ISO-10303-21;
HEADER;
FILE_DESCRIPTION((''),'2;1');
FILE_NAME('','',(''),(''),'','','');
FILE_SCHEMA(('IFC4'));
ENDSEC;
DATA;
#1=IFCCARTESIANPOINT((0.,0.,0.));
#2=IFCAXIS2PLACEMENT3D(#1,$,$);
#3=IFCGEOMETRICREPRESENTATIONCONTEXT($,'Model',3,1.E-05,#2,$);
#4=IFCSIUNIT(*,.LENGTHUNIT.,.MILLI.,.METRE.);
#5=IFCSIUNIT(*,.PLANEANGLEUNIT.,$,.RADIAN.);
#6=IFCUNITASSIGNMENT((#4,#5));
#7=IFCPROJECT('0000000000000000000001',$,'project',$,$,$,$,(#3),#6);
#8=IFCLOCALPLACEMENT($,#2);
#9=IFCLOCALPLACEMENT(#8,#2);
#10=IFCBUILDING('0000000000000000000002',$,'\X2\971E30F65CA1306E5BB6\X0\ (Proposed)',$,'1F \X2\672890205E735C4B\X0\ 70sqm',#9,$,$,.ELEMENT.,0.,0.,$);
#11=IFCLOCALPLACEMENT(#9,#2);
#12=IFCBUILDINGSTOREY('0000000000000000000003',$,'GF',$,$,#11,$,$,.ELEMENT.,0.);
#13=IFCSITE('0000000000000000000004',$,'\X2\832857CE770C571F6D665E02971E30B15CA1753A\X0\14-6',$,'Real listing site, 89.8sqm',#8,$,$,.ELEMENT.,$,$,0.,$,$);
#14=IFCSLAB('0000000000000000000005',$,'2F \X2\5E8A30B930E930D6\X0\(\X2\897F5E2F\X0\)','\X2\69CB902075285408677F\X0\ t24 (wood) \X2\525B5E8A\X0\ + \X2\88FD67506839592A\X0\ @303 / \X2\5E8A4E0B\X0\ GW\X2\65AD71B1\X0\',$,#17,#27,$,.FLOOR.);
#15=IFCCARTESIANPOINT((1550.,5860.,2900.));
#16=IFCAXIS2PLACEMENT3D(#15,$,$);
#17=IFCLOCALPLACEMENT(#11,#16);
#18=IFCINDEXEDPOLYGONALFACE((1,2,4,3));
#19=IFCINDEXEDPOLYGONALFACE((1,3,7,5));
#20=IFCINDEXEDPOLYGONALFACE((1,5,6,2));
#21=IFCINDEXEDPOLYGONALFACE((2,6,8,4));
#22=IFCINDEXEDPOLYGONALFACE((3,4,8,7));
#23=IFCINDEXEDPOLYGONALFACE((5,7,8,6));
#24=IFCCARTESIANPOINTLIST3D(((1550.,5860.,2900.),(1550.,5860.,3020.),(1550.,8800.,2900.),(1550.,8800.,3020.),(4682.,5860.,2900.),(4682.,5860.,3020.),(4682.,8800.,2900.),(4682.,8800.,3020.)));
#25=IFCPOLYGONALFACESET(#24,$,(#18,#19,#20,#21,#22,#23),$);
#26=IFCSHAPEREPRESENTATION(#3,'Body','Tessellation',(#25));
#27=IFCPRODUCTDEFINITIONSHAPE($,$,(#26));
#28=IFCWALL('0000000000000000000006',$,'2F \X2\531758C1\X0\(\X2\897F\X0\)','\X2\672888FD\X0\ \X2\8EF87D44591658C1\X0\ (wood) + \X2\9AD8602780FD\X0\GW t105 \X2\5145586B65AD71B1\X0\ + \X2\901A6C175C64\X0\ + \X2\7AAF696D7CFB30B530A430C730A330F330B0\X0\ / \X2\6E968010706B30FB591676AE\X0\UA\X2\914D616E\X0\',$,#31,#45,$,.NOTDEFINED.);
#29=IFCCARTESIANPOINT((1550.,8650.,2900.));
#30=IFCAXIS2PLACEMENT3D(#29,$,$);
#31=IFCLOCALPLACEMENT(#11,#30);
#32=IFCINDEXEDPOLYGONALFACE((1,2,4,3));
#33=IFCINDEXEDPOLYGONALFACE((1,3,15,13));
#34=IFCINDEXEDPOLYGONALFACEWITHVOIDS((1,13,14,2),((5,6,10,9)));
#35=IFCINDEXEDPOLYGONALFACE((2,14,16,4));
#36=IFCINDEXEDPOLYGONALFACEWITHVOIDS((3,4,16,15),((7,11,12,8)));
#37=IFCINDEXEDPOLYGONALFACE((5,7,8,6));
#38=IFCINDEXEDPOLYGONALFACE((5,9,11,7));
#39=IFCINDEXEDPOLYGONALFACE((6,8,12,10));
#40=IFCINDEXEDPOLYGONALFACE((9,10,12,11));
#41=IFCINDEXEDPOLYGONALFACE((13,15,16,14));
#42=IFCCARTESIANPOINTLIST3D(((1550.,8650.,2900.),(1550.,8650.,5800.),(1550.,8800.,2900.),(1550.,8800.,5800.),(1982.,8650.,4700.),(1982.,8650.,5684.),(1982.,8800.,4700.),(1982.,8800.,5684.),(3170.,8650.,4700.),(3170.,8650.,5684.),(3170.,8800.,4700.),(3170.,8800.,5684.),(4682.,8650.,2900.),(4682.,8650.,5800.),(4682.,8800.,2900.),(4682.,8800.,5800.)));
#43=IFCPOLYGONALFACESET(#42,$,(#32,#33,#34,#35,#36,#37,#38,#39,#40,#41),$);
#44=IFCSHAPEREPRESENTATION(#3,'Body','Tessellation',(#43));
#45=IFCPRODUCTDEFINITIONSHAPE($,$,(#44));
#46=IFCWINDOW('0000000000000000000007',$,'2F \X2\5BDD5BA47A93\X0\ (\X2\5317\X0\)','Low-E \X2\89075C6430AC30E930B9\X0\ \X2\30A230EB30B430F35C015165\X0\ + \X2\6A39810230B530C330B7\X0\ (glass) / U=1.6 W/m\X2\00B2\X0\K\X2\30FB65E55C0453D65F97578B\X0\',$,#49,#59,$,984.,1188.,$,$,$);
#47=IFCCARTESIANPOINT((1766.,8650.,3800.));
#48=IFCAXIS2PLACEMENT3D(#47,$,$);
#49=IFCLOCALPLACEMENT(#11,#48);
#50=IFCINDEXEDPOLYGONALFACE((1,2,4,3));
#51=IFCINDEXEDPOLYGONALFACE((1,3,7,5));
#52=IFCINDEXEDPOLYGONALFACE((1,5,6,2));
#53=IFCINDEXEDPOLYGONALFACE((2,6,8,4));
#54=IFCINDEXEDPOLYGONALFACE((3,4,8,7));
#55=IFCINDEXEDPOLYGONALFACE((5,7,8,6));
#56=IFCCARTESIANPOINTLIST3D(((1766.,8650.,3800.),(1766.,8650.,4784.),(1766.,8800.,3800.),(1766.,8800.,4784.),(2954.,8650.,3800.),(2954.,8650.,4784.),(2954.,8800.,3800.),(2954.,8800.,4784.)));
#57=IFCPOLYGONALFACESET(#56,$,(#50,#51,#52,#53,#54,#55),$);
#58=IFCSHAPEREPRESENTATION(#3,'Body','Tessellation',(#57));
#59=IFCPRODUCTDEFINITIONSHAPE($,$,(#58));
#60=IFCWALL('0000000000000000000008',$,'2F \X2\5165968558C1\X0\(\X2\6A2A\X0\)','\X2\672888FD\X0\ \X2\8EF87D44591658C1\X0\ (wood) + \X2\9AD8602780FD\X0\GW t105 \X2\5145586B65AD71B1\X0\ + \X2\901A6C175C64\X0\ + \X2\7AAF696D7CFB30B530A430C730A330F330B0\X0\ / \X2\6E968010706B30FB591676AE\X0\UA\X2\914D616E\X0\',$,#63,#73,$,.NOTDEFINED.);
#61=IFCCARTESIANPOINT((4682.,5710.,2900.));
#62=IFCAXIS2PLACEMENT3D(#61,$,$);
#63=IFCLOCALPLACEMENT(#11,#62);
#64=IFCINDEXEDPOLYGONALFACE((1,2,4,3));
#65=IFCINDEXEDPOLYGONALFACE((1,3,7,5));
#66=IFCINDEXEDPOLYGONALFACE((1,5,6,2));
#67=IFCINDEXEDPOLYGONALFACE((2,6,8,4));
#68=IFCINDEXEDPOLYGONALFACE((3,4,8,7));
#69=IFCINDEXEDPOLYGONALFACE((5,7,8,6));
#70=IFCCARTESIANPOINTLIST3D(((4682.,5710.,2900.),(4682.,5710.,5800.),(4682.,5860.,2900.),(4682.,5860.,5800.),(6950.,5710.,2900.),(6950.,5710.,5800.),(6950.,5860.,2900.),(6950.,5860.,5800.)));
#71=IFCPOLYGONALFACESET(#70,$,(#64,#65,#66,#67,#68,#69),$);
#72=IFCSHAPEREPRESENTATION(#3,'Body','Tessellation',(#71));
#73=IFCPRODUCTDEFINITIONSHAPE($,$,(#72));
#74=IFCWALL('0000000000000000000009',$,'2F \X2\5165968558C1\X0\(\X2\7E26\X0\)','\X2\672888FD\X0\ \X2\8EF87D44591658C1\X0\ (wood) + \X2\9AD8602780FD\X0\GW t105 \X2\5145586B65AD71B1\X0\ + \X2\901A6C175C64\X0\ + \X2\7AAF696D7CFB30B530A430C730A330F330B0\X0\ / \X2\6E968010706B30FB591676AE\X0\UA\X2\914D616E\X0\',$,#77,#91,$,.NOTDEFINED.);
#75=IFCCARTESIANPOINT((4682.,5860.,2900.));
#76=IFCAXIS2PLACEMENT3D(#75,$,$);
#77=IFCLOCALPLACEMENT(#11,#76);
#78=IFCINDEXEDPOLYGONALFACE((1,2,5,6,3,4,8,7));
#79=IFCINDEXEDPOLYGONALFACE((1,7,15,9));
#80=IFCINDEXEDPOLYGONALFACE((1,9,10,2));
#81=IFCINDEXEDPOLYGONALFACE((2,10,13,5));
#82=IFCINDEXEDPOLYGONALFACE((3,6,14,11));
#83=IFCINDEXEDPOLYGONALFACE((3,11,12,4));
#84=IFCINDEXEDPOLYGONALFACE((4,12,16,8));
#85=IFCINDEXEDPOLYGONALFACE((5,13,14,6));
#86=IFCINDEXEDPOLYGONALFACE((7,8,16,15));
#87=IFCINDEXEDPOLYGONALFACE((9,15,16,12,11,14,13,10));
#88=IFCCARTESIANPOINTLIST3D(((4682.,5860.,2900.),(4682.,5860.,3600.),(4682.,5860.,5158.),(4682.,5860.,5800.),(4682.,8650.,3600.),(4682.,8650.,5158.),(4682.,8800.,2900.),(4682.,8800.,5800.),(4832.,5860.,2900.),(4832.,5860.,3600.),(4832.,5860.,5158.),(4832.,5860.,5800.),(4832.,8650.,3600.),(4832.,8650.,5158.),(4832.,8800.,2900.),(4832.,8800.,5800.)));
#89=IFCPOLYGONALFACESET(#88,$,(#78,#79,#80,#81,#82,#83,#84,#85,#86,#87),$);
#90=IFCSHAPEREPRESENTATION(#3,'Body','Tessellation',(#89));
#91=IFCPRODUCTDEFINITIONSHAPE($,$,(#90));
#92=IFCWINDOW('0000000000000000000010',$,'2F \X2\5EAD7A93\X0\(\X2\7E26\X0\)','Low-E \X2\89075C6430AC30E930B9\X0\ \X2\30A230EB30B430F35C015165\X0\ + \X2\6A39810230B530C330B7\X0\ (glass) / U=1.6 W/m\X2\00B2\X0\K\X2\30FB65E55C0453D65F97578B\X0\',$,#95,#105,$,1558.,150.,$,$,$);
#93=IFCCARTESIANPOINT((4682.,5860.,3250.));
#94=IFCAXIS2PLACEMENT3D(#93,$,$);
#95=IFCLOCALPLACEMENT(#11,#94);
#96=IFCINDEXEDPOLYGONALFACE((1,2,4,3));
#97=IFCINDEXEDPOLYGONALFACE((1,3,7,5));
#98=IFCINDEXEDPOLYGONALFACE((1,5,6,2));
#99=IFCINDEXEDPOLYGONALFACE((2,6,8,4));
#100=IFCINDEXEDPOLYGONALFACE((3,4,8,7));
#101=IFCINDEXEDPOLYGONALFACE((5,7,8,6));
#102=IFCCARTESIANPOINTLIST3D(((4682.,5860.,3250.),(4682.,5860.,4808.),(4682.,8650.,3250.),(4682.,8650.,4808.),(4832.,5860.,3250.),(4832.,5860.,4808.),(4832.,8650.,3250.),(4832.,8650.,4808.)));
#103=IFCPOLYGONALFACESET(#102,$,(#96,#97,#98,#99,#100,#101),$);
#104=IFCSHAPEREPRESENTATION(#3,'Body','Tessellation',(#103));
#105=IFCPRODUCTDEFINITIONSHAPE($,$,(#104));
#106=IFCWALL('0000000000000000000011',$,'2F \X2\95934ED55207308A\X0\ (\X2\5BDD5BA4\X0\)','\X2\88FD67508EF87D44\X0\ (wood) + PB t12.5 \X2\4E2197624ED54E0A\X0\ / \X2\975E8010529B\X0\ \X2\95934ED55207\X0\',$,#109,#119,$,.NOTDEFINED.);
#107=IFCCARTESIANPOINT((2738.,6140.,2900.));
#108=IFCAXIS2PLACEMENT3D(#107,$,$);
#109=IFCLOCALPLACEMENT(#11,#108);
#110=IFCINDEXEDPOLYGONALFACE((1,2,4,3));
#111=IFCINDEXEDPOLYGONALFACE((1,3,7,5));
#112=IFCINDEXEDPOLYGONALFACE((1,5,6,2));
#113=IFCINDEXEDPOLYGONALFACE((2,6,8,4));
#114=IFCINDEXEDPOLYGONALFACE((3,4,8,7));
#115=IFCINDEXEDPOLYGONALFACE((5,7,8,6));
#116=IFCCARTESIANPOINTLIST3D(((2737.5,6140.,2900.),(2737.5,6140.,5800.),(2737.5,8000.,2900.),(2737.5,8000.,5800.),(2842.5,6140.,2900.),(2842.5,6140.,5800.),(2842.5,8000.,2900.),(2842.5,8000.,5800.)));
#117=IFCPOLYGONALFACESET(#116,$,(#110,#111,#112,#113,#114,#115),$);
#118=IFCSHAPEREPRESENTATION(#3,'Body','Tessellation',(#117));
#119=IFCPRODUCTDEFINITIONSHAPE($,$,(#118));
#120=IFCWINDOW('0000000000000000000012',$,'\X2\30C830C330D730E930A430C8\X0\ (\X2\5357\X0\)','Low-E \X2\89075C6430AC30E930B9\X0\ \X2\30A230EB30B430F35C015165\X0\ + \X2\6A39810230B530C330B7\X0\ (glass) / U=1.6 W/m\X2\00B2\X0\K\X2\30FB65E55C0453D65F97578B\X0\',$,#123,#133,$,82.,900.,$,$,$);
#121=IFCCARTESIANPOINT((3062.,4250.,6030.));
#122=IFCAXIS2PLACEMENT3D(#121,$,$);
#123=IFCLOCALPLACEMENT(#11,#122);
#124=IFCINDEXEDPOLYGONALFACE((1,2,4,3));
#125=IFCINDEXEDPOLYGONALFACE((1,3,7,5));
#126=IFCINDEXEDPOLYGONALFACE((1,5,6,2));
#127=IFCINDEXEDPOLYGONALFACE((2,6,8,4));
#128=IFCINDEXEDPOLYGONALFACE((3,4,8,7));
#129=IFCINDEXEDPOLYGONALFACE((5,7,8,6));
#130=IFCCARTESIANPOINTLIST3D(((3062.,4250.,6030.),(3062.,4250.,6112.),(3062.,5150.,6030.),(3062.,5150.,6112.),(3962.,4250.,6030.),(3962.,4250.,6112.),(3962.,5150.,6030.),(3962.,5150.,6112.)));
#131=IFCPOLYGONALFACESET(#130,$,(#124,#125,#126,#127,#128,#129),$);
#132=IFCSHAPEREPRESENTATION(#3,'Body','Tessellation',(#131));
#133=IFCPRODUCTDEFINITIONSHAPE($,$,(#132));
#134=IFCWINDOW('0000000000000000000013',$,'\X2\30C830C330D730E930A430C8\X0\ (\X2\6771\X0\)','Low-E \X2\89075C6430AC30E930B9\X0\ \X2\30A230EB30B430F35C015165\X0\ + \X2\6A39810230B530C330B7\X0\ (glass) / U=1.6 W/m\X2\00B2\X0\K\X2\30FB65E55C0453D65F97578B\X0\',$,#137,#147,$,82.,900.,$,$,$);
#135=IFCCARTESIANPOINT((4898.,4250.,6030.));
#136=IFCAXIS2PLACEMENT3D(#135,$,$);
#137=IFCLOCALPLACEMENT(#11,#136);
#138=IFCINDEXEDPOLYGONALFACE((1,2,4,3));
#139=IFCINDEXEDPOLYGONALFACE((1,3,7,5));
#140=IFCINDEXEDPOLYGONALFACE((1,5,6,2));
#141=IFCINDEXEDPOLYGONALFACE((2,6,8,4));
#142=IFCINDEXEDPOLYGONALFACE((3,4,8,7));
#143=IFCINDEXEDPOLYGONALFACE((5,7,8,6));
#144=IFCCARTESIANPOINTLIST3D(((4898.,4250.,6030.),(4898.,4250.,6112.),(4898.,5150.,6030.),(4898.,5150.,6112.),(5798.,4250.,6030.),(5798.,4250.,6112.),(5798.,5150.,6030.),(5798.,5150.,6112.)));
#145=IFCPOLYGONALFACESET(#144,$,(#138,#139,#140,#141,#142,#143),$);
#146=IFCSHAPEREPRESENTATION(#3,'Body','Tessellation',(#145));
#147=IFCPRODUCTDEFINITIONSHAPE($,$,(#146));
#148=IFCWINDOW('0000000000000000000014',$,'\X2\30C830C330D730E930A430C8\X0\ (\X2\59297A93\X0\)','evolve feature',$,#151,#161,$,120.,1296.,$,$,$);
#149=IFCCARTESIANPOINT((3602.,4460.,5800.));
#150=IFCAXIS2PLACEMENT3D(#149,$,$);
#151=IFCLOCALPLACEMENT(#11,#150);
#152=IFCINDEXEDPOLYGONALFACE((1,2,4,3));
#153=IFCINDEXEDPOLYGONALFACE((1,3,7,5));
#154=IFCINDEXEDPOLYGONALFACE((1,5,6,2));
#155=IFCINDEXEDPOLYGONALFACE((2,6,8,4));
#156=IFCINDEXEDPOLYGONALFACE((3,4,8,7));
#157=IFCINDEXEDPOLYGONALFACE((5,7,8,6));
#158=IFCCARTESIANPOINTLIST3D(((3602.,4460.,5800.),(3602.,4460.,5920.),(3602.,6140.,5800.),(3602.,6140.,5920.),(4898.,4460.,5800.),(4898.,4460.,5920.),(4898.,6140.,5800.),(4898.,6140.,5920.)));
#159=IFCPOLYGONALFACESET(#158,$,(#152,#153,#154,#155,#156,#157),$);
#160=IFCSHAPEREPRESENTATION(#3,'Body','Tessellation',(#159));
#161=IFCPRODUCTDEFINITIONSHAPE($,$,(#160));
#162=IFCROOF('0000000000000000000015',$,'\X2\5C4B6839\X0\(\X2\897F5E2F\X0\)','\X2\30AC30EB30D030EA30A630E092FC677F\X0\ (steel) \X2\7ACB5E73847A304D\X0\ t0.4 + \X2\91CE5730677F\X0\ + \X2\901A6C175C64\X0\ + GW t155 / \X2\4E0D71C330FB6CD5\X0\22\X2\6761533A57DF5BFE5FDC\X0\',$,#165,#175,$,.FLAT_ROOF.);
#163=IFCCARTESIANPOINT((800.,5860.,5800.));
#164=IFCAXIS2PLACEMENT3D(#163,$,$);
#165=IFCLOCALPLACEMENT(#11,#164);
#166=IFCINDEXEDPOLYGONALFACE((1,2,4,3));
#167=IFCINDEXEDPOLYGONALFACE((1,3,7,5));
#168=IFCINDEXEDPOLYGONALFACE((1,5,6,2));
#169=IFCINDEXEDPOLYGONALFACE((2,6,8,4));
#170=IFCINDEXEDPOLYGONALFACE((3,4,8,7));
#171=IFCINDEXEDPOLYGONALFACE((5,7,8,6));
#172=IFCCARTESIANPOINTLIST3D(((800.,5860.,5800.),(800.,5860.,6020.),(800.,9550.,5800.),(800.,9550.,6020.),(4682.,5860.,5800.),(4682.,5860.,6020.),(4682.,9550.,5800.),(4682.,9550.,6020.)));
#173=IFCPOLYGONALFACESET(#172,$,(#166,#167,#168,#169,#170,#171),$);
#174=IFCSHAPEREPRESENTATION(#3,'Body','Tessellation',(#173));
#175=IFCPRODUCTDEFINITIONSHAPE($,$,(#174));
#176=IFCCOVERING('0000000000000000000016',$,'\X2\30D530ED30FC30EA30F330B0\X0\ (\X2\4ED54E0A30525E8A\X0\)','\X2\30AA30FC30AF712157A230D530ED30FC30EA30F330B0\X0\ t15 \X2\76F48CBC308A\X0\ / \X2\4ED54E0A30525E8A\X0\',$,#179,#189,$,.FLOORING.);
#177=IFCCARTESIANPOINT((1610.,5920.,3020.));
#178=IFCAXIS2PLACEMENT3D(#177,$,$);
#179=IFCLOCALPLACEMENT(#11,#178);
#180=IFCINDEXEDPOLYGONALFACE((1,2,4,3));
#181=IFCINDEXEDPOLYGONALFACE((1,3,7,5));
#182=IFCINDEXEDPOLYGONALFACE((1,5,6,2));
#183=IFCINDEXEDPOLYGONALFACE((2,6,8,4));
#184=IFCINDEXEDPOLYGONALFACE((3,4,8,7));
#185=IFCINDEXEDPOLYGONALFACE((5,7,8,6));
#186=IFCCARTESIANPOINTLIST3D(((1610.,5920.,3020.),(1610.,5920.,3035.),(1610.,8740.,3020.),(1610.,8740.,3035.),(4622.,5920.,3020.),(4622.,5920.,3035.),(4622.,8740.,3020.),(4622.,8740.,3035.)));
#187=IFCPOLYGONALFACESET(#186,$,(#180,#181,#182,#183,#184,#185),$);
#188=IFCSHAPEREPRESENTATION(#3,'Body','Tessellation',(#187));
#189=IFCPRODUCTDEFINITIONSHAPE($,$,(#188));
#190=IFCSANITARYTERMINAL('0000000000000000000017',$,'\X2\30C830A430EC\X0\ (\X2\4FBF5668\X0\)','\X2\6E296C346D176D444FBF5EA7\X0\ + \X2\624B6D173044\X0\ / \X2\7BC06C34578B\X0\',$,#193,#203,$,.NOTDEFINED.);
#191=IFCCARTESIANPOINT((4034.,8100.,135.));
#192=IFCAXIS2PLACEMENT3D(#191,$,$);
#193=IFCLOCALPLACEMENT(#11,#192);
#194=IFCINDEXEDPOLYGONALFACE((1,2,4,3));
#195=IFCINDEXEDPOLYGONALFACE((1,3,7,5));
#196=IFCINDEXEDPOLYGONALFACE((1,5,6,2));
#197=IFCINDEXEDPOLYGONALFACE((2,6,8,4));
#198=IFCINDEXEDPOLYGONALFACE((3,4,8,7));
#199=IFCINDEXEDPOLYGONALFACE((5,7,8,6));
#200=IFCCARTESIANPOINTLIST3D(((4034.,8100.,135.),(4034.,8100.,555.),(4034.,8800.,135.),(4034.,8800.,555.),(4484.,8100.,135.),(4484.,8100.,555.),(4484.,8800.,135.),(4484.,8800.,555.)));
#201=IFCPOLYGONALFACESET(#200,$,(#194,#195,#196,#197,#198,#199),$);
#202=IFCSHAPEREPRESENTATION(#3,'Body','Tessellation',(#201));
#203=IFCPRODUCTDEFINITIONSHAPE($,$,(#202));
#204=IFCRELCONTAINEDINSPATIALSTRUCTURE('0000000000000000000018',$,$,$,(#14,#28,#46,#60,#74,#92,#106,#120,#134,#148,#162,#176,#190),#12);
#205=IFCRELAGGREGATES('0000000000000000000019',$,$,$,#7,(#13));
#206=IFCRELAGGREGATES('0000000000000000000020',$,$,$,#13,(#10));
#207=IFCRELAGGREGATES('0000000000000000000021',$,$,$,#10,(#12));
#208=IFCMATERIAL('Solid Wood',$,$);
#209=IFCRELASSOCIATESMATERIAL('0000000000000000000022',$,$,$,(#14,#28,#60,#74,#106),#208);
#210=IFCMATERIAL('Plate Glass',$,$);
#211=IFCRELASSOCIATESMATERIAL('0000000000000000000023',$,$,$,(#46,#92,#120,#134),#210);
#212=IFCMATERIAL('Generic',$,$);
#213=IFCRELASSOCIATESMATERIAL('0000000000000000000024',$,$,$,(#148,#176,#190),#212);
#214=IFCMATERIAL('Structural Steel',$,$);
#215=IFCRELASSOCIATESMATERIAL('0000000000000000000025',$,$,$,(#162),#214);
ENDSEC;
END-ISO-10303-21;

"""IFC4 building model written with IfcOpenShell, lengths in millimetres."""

from ifc_helpers import new_model, si_unit, frame, frame_2d, origin, place, context, project, spatial, rectangle, extrude, material, element, fill, save


model = new_model("IFC4")

# Units and contexts
model_context = context("Model", 3, precision=1e-05, world=origin())
ifc_project = project(units=[si_unit("LENGTHUNIT", "METRE", prefix="MILLI"), si_unit("PLANEANGLEUNIT", "RADIAN")], contexts=[model_context])

# Site, building, storey
site_placement = place(None, origin())
site = spatial("IfcSite", under=ifc_project, at=site_placement, Name="茨城県土浦市霞ケ岡町14-6", ObjectType="Real listing site, 89.8sqm", CompositionType="ELEMENT", RefElevation=0.0)
building_placement = place(site_placement, origin())
building = spatial("IfcBuilding", under=site, at=building_placement, Name="霞ヶ岡の家 (Proposed)", ObjectType="1F 木造平屋 70sqm", CompositionType="ELEMENT", ElevationOfRefHeight=0.0, ElevationOfTerrain=0.0)
storey_placement = place(building_placement, origin())
storey = spatial("IfcBuildingStorey", under=building, at=storey_placement, Name="GF", CompositionType="ELEMENT", Elevation=0.0)

# Slab
ifc_material_1 = material(Name="Solid Wood")
slab_placement = place(storey_placement, frame((1550.0, 5860.0, 2900.0)))
element("IfcSlab", 1, at=slab_placement, inside=storey, material=ifc_material_1, Name="2F 床スラブ(西帯)", Description="構造用合板 t24 (wood) 剛床 + 製材根太 @303 / 床下 GW断熱", PredefinedType="FLOOR", context=model_context, shape_type="SweptSolid", body=[
    extrude(rectangle(XDim=3132.0, YDim=2940.0, at=frame_2d((1566.0, 1470.0))), frame((1550.0, 5860.0, 2900.0)), (0.0, 0.0, 1.0), 120.0),
])

# Wall, opening, window
wall_1_placement = place(storey_placement, frame((1550.0, 8650.0, 2900.0)))
wall_1 = element("IfcWall", 2, at=wall_1_placement, inside=storey, material=ifc_material_1, Name="2F 北壁(西)", Description="木製 軸組外壁 (wood) + 高性能GW t105 充填断熱 + 通気層 + 窯業系サイディング / 準耐火・外皮UA配慮", PredefinedType="NOTDEFINED", context=model_context, shape_type="SweptSolid", body=[
    extrude(rectangle(XDim=3132.0, YDim=150.0, at=frame_2d((1566.0, 75.0))), frame((1550.0, 8650.0, 2900.0)), (0.0, 0.0, 1.0), 2900.0),
])
opening_1_placement = place(storey_placement, frame((1766.0, 8650.0, 3800.0)))
opening_1 = element("IfcOpeningElement", 3, at=opening_1_placement, cuts=wall_1, PredefinedType="NOTDEFINED", context=model_context, shape_type="SweptSolid", body=[
    extrude(rectangle(XDim=1188.0, YDim=150.0, at=frame_2d((594.0, 75.0))), frame((1766.0, 8650.0, 3800.0)), (0.0, 0.0, 1.0), 984.0),
])
ifc_material_2 = material(Name="Plate Glass")
window_1_placement = place(storey_placement, frame((1766.0, 8650.0, 3800.0)))
window_1 = element("IfcWindow", 4, at=window_1_placement, inside=storey, material=ifc_material_2, Name="2F 寝室窓 (北)", Description="Low-E 複層ガラス アルゴン封入 + 樹脂サッシ (glass) / U=1.6 W/m²K・日射取得型", OverallHeight=984.0, OverallWidth=1188.0, context=model_context, shape_type="SweptSolid", body=[
    extrude(rectangle(XDim=1188.0, YDim=150.0, at=frame_2d((594.0, 75.0))), frame((1766.0, 8650.0, 3800.0)), (0.0, 0.0, 1.0), 984.0),
])
fill(opening_1, window_1)

# Wall
wall_2_placement = place(storey_placement, frame((4682.0, 5710.0, 2900.0)))
element("IfcWall", 5, at=wall_2_placement, inside=storey, material=ifc_material_1, Name="2F 入隅壁(横)", Description="木製 軸組外壁 (wood) + 高性能GW t105 充填断熱 + 通気層 + 窯業系サイディング / 準耐火・外皮UA配慮", PredefinedType="NOTDEFINED", context=model_context, shape_type="SweptSolid", body=[
    extrude(rectangle(XDim=2268.0, YDim=150.0, at=frame_2d((1134.0, 75.0))), frame((4682.0, 5710.0, 2900.0)), (0.0, 0.0, 1.0), 2900.0),
])

# Wall, opening, window
wall_3_placement = place(storey_placement, frame((4682.0, 5860.0, 2900.0)))
wall_3 = element("IfcWall", 6, at=wall_3_placement, inside=storey, material=ifc_material_1, Name="2F 入隅壁(縦)", Description="木製 軸組外壁 (wood) + 高性能GW t105 充填断熱 + 通気層 + 窯業系サイディング / 準耐火・外皮UA配慮", PredefinedType="NOTDEFINED", context=model_context, shape_type="SweptSolid", body=[
    extrude(rectangle(XDim=150.0, YDim=2940.0, at=frame_2d((75.0, 1470.0))), frame((4682.0, 5860.0, 2900.0)), (0.0, 0.0, 1.0), 2900.0),
])
opening_2_placement = place(storey_placement, frame((4682.0, 5860.0, 3250.0)))
opening_2 = element("IfcOpeningElement", 7, at=opening_2_placement, cuts=wall_3, PredefinedType="NOTDEFINED", context=model_context, shape_type="SweptSolid", body=[
    extrude(rectangle(XDim=150.0, YDim=2790.0, at=frame_2d((75.0, 1395.0))), frame((4682.0, 5860.0, 3250.0)), (0.0, 0.0, 1.0), 1558.0),
])
window_2_placement = place(storey_placement, frame((4682.0, 5860.0, 3250.0)))
window_2 = element("IfcWindow", 8, at=window_2_placement, inside=storey, material=ifc_material_2, Name="2F 庭窓(縦)", Description="Low-E 複層ガラス アルゴン封入 + 樹脂サッシ (glass) / U=1.6 W/m²K・日射取得型", OverallHeight=1558.0, OverallWidth=150.0, context=model_context, shape_type="SweptSolid", body=[
    extrude(rectangle(XDim=150.0, YDim=2790.0, at=frame_2d((75.0, 1395.0))), frame((4682.0, 5860.0, 3250.0)), (0.0, 0.0, 1.0), 1558.0),
])
fill(opening_2, window_2)

# Wall
wall_4_placement = place(storey_placement, frame((2738.0, 6140.0, 2900.0)))
element("IfcWall", 9, at=wall_4_placement, inside=storey, material=ifc_material_1, Name="2F 間仕切り (寝室)", Description="製材軸組 (wood) + PB t12.5 両面仕上 / 非耐力 間仕切", PredefinedType="NOTDEFINED", context=model_context, shape_type="SweptSolid", body=[
    extrude(rectangle(XDim=105.0, YDim=1860.0, at=frame_2d((52.0, 930.0))), frame((2738.0, 6140.0, 2900.0)), (0.0, 0.0, 1.0), 2900.0),
])

# Windows
window_3_placement = place(storey_placement, frame((3062.0, 4250.0, 6030.0)))
element("IfcWindow", 10, at=window_3_placement, inside=storey, material=ifc_material_2, Name="トップライト (南)", Description="Low-E 複層ガラス アルゴン封入 + 樹脂サッシ (glass) / U=1.6 W/m²K・日射取得型", OverallHeight=82.0, OverallWidth=900.0, context=model_context, shape_type="SweptSolid", body=[
    extrude(rectangle(XDim=900.0, YDim=900.0, at=frame_2d((450.0, 450.0))), frame((3062.0, 4250.0, 6030.0)), (0.0, 0.0, 1.0), 82.0),
])
window_4_placement = place(storey_placement, frame((4898.0, 4250.0, 6030.0)))
element("IfcWindow", 11, at=window_4_placement, inside=storey, material=ifc_material_2, Name="トップライト (東)", Description="Low-E 複層ガラス アルゴン封入 + 樹脂サッシ (glass) / U=1.6 W/m²K・日射取得型", OverallHeight=82.0, OverallWidth=900.0, context=model_context, shape_type="SweptSolid", body=[
    extrude(rectangle(XDim=900.0, YDim=900.0, at=frame_2d((450.0, 450.0))), frame((4898.0, 4250.0, 6030.0)), (0.0, 0.0, 1.0), 82.0),
])
ifc_material_3 = material(Name="Generic")
window_5_placement = place(storey_placement, frame((3602.0, 4460.0, 5800.0)))
element("IfcWindow", 12, at=window_5_placement, inside=storey, material=ifc_material_3, Name="トップライト (天窓)", Description="evolve feature", OverallHeight=120.0, OverallWidth=1296.0, context=model_context, shape_type="SweptSolid", body=[
    extrude(rectangle(XDim=1296.0, YDim=1680.0, at=frame_2d((648.0, 840.0))), frame((3602.0, 4460.0, 5800.0)), (0.0, 0.0, 1.0), 120.0),
])

# Roof
ifc_material_4 = material(Name="Structural Steel")
for number, where, name in (
    (13, (800.0, 5860.0, 5800.0), "屋根(西帯)"),
):
    element("IfcRoof", number, at=place(storey_placement, frame(where)), inside=storey, material=ifc_material_4, Name=name, Description="ガルバリウム鋼板 (steel) 立平葺き t0.4 + 野地板 + 通気層 + GW t155 / 不燃・法22条区域対応", PredefinedType="FLAT_ROOF", context=model_context, shape_type="SweptSolid", body=[
        extrude(rectangle(XDim=3882.0, YDim=3690.0, at=frame_2d((1941.0, 1845.0))), frame((800.0, 5860.0, 5800.0)), (0.0, 0.0, 1.0), 220.0),
    ])

# Covering
covering_placement = place(storey_placement, frame((1610.0, 5920.0, 3020.0)))
element("IfcCovering", 14, at=covering_placement, inside=storey, material=ifc_material_3, Name="フローリング (仕上げ床)", Description="オーク無垢フローリング t15 直貼り / 仕上げ床", PredefinedType="FLOORING", context=model_context, shape_type="SweptSolid", body=[
    extrude(rectangle(XDim=3012.0, YDim=2820.0, at=frame_2d((1506.0, 1410.0))), frame((1610.0, 5920.0, 3020.0)), (0.0, 0.0, 1.0), 15.0),
])

# Sanitary terminal
sanitary_terminal_placement = place(storey_placement, frame((4034.0, 8100.0, 135.0)))
element("IfcSanitaryTerminal", 15, at=sanitary_terminal_placement, inside=storey, material=ifc_material_3, Name="トイレ (便器)", Description="温水洗浄便座 + 手洗い / 節水型", PredefinedType="NOTDEFINED", context=model_context, shape_type="SweptSolid", body=[
    extrude(rectangle(XDim=450.0, YDim=700.0, at=frame_2d((225.0, 350.0))), frame((4034.0, 8100.0, 135.0)), (0.0, 0.0, 1.0), 420.0),
])

save(model, "model.ifc")
